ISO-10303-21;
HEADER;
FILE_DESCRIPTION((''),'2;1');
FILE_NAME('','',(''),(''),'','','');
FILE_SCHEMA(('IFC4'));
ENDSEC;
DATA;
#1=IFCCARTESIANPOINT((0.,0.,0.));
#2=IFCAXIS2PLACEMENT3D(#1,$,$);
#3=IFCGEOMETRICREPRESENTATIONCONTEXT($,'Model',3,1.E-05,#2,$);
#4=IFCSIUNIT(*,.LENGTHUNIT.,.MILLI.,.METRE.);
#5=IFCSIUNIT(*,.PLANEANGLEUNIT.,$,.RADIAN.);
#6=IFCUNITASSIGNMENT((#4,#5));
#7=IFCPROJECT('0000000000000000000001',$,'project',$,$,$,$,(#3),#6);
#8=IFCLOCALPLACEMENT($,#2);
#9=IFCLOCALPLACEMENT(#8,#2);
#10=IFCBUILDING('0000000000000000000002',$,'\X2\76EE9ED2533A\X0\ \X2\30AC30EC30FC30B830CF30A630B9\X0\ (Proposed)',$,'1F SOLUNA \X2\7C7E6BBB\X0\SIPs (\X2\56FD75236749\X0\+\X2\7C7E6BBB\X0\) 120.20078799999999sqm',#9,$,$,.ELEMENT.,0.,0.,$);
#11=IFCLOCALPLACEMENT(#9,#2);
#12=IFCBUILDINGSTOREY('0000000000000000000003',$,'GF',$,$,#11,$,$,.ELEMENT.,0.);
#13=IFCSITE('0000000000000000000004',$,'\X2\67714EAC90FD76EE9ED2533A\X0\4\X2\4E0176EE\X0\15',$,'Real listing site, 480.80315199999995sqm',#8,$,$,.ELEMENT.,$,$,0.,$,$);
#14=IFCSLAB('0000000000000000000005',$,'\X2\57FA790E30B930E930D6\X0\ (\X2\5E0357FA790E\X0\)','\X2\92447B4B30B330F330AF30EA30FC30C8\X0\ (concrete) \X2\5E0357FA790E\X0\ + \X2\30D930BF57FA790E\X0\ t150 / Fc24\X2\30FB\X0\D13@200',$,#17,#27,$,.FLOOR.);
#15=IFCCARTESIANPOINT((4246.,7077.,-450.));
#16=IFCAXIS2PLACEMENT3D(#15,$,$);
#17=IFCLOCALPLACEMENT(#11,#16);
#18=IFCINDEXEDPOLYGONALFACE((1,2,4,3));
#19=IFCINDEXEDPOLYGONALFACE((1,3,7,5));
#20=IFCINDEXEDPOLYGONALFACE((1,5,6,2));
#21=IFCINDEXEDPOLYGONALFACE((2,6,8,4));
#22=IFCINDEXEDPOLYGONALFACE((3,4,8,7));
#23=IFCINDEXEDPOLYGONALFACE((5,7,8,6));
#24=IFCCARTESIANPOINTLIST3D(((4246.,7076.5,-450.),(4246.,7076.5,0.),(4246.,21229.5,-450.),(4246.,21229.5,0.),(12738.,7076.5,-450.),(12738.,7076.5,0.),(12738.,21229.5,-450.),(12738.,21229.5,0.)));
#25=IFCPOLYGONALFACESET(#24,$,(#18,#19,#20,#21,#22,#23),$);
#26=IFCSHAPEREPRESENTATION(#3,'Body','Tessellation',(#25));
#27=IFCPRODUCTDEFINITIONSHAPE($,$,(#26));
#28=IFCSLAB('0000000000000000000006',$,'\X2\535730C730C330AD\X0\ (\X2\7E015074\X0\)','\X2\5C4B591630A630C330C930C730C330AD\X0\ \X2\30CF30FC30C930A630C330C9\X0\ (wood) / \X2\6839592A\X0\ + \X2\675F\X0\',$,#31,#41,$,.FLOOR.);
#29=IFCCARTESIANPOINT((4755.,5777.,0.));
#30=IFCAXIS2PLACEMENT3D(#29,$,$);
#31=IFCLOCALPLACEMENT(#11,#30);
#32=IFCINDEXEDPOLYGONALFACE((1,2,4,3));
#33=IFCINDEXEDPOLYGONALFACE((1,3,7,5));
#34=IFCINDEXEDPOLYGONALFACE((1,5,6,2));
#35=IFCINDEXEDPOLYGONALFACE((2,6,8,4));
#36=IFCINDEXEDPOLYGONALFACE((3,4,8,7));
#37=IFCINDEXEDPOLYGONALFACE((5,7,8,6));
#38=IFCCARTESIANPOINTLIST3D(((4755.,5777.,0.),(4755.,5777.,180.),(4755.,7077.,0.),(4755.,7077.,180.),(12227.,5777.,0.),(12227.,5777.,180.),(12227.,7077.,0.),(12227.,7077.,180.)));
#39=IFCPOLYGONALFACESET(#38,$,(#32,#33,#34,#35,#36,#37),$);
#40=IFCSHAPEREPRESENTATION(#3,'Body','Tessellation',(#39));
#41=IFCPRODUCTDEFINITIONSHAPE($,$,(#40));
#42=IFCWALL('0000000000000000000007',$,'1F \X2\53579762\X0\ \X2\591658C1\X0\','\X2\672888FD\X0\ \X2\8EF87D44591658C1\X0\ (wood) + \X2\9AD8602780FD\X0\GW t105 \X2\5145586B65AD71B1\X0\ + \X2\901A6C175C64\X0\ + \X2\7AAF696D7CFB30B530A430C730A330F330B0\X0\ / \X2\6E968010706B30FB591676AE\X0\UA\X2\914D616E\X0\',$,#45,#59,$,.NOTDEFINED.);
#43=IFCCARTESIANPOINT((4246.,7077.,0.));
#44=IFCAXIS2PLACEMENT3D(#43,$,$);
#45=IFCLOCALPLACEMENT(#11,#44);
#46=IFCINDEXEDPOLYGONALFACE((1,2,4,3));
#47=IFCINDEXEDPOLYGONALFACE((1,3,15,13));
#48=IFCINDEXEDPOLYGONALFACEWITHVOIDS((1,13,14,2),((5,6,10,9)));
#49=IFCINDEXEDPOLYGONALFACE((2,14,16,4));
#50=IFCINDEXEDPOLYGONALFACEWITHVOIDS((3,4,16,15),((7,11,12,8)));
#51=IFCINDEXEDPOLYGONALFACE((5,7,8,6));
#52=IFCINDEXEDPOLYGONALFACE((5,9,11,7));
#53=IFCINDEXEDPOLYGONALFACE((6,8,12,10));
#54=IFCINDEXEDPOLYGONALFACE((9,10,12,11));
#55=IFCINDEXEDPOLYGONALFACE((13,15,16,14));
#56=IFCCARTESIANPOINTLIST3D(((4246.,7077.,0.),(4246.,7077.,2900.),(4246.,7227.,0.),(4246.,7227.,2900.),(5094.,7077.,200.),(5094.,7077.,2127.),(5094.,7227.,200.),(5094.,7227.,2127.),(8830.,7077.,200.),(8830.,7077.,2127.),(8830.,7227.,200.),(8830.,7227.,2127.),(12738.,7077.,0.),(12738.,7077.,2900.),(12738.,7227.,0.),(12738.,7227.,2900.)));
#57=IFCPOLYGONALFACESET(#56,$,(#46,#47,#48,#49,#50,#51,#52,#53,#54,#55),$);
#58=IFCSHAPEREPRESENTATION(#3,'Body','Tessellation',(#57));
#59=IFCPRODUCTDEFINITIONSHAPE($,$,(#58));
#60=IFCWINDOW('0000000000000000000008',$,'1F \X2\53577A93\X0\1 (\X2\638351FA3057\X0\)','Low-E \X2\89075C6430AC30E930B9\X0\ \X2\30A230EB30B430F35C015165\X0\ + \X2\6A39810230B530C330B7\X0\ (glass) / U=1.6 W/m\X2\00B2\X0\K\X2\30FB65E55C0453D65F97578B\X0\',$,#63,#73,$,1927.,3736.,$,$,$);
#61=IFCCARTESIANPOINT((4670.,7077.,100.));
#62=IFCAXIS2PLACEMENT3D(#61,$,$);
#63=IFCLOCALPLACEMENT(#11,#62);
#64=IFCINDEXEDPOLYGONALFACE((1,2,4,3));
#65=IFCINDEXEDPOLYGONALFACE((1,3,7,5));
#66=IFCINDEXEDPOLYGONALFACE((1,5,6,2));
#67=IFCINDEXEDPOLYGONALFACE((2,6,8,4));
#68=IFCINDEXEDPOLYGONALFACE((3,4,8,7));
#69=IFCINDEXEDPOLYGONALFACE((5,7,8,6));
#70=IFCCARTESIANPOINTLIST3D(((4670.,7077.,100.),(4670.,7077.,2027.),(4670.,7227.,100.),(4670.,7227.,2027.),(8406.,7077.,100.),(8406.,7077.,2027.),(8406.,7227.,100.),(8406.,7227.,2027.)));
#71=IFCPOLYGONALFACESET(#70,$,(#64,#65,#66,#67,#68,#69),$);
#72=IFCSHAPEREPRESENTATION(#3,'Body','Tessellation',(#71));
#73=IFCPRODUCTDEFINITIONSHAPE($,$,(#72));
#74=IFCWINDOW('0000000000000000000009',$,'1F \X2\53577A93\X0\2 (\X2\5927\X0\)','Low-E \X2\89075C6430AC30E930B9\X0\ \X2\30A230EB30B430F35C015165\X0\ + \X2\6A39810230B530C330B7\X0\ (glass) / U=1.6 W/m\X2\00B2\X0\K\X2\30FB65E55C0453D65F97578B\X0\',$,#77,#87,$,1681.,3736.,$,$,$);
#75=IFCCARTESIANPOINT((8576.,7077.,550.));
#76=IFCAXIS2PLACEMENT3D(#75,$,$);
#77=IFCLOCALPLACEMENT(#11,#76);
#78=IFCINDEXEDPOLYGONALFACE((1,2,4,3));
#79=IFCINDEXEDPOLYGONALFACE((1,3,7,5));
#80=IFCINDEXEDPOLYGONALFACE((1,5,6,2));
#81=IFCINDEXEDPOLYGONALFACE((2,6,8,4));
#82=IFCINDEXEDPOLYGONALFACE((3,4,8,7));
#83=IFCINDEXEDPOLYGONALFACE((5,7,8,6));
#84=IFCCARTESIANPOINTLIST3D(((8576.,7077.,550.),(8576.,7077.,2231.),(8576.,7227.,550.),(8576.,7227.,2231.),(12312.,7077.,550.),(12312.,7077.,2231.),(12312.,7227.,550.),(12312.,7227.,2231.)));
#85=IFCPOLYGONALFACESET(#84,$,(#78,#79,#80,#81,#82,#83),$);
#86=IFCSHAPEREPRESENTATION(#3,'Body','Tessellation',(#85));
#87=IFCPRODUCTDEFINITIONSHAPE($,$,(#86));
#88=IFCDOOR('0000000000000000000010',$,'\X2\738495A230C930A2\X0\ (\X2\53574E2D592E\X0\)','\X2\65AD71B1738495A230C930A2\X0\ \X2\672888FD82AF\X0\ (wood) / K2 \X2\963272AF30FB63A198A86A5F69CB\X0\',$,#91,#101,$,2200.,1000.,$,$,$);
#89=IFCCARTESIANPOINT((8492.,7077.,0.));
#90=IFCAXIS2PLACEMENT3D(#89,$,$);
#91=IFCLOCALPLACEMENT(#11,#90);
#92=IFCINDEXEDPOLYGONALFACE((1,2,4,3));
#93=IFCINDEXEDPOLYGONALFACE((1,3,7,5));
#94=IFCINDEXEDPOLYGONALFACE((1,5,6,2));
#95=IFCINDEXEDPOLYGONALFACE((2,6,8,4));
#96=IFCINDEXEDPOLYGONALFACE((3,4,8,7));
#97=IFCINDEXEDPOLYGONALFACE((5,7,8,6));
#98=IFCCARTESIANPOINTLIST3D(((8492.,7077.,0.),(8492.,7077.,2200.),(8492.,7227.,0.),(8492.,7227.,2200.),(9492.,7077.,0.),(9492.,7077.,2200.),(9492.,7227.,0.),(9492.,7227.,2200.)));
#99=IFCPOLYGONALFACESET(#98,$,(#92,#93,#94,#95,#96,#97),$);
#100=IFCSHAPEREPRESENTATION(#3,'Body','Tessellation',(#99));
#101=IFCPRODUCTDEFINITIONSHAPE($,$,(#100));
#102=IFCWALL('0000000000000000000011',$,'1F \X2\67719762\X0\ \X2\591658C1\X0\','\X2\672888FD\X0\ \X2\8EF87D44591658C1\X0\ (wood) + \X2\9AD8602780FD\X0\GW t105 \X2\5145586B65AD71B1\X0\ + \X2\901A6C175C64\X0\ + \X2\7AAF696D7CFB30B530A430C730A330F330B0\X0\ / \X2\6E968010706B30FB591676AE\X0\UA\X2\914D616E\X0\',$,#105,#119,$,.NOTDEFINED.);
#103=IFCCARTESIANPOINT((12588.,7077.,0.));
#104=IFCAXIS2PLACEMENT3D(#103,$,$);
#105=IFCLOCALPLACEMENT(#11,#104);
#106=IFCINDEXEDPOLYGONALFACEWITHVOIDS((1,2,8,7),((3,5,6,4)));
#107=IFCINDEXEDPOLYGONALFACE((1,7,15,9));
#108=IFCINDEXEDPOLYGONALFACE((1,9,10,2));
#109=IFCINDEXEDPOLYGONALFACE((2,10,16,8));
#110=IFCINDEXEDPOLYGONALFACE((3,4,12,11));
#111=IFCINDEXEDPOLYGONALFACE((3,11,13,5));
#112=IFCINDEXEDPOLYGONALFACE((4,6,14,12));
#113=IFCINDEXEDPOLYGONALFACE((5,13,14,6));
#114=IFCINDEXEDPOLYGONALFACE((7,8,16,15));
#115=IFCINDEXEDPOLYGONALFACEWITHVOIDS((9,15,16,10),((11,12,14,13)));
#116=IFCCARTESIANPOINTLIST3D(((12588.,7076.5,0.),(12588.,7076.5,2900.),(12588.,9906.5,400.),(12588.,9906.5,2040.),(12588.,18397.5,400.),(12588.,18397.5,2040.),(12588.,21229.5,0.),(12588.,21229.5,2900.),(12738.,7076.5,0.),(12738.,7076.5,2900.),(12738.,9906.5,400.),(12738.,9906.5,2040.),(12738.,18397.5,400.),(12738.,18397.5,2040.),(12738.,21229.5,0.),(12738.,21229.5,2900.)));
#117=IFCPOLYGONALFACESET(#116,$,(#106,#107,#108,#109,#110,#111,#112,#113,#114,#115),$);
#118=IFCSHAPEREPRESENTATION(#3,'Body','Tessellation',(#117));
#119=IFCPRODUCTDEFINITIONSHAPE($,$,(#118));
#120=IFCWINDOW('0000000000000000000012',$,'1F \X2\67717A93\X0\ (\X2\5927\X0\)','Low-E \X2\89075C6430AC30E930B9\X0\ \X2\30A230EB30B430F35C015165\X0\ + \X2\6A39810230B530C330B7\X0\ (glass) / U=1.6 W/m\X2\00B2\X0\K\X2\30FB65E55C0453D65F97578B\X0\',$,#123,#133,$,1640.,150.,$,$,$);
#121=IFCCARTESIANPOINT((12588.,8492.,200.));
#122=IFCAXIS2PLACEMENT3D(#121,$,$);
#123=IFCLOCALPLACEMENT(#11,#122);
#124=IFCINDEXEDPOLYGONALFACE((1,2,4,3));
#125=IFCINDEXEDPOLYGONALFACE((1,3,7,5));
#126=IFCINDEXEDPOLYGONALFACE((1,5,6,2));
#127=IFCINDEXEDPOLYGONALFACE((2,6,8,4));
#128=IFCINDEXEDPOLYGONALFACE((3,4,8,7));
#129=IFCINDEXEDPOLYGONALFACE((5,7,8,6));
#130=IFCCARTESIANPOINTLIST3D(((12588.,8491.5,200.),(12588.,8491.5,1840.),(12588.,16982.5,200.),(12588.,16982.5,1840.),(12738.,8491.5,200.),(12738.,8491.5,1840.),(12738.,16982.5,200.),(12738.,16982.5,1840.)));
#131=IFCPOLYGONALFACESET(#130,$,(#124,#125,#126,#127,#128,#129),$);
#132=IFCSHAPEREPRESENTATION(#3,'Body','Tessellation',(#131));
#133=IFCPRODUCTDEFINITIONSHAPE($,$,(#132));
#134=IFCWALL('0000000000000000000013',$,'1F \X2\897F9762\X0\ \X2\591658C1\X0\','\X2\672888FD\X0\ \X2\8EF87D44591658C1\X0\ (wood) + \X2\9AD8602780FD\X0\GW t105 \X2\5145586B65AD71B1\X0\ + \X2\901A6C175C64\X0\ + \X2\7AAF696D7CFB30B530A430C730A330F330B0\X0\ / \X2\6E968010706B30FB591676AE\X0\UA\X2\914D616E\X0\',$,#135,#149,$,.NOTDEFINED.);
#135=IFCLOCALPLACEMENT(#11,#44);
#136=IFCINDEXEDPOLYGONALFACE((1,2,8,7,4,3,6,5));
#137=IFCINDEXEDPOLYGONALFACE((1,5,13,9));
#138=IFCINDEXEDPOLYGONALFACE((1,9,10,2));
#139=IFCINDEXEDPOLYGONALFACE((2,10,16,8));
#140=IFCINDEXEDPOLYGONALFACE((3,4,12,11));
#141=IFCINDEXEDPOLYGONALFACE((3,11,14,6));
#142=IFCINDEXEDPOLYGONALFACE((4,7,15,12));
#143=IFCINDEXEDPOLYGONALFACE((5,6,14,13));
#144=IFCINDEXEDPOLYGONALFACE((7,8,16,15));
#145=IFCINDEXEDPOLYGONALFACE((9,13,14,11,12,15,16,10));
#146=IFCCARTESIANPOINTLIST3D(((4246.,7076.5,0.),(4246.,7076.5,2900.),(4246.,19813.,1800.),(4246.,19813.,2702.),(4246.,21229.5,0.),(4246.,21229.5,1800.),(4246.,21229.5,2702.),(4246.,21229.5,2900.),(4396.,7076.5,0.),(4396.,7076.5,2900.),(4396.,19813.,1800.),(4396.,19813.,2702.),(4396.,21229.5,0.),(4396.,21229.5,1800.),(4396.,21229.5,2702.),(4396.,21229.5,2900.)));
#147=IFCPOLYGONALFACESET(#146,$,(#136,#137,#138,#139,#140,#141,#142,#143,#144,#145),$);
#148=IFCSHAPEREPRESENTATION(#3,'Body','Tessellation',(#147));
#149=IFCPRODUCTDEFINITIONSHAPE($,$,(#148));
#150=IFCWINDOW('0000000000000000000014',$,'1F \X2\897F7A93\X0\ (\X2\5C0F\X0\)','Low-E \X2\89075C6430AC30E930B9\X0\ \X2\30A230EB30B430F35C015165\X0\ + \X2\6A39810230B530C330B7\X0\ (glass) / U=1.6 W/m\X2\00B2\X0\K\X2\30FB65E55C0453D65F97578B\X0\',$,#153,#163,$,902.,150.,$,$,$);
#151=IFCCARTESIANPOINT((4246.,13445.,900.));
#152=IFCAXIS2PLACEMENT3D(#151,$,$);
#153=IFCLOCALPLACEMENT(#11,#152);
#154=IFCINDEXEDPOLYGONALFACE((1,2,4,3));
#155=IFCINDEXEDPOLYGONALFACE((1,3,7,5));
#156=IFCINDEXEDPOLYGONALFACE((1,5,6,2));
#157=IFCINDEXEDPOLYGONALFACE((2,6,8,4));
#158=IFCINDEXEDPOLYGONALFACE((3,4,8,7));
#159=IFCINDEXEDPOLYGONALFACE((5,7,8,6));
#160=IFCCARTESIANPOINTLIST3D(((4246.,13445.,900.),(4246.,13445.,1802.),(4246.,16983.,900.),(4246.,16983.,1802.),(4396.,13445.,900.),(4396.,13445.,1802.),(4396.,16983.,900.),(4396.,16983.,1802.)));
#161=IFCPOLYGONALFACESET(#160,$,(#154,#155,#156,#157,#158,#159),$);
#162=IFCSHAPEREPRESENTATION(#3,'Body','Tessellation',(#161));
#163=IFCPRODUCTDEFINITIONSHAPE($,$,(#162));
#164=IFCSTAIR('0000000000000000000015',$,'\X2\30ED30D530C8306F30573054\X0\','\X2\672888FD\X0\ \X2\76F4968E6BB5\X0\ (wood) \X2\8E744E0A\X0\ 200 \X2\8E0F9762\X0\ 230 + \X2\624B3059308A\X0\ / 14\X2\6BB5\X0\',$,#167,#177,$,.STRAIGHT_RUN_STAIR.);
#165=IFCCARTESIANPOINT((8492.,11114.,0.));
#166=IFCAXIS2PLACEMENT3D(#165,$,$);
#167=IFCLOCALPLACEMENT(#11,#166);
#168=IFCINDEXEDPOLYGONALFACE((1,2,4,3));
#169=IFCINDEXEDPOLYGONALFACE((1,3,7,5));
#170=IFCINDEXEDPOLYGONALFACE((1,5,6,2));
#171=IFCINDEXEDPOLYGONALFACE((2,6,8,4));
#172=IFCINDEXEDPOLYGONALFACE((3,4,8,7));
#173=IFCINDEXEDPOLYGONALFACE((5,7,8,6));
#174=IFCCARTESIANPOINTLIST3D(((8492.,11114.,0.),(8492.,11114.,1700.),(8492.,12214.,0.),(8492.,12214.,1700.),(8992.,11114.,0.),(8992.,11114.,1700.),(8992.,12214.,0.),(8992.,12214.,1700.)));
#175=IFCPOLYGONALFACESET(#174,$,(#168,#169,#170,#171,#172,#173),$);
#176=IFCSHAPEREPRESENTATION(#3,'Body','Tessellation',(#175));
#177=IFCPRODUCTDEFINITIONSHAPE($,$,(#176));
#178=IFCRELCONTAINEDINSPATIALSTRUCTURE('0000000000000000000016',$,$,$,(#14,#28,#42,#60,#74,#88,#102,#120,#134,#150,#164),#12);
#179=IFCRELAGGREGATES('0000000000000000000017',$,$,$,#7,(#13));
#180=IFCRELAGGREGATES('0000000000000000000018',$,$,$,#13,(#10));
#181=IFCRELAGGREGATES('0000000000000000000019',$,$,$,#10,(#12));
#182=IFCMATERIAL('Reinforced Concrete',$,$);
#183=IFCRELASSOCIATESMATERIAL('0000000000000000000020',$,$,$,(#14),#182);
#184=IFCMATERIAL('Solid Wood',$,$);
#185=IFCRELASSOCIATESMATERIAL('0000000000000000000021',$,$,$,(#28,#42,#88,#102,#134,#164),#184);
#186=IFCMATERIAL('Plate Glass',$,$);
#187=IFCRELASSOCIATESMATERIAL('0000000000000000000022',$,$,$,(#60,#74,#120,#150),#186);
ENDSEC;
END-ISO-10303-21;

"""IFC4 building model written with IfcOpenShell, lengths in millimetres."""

from ifc_helpers import new_model, si_unit, frame, frame_2d, origin, place, context, project, spatial, rectangle, extrude, material, element, fill, save


model = new_model("IFC4")

# Units and contexts
model_context = context("Model", 3, precision=1e-05, world=origin())
ifc_project = project(units=[si_unit("LENGTHUNIT", "METRE", prefix="MILLI"), si_unit("PLANEANGLEUNIT", "RADIAN")], contexts=[model_context])

# Site, building, storey
site_placement = place(None, origin())
site = spatial("IfcSite", under=ifc_project, at=site_placement, Name="東京都目黒区4丁目15", ObjectType="Real listing site, 480.80315199999995sqm", CompositionType="ELEMENT", RefElevation=0.0)
building_placement = place(site_placement, origin())
building = spatial("IfcBuilding", under=site, at=building_placement, Name="目黒区 ガレージハウス (Proposed)", ObjectType="1F SOLUNA 籾殻SIPs (国産杉+籾殻) 120.20078799999999sqm", CompositionType="ELEMENT", ElevationOfRefHeight=0.0, ElevationOfTerrain=0.0)
storey_placement = place(building_placement, origin())
storey = spatial("IfcBuildingStorey", under=building, at=storey_placement, Name="GF", CompositionType="ELEMENT", Elevation=0.0)

# Slabs
ifc_material_1 = material(Name="Reinforced Concrete")
slab_1_placement = place(storey_placement, frame((4246.0, 7077.0, -450.0)))
element("IfcSlab", 1, at=slab_1_placement, inside=storey, material=ifc_material_1, Name="基礎スラブ (布基礎)", Description="鉄筋コンクリート (concrete) 布基礎 + ベタ基礎 t150 / Fc24・D13@200", PredefinedType="FLOOR", context=model_context, shape_type="SweptSolid", body=[
    extrude(rectangle(XDim=8492.0, YDim=14153.0, at=frame_2d((4246.0, 7076.0))), frame((4246.0, 7077.0, -450.0)), (0.0, 0.0, 1.0), 450.0),
])
ifc_material_2 = material(Name="Solid Wood")
slab_2_placement = place(storey_placement, frame((4755.0, 5777.0, 0.0)))
element("IfcSlab", 2, at=slab_2_placement, inside=storey, material=ifc_material_2, Name="南デッキ (縁側)", Description="屋外ウッドデッキ ハードウッド (wood) / 根太 + 束", PredefinedType="FLOOR", context=model_context, shape_type="SweptSolid", body=[
    extrude(rectangle(XDim=7472.0, YDim=1300.0, at=frame_2d((3736.0, 650.0))), frame((4755.0, 5777.0, 0.0)), (0.0, 0.0, 1.0), 180.0),
])

# Wall, openings, windows, door
wall_1_placement = place(storey_placement, frame((4246.0, 7077.0, 0.0)))
wall_1 = element("IfcWall", 3, at=wall_1_placement, inside=storey, material=ifc_material_2, Name="1F 南面 外壁", Description="木製 軸組外壁 (wood) + 高性能GW t105 充填断熱 + 通気層 + 窯業系サイディング / 準耐火・外皮UA配慮", PredefinedType="NOTDEFINED", context=model_context, shape_type="SweptSolid", body=[
    extrude(rectangle(XDim=8492.0, YDim=150.0, at=frame_2d((4246.0, 75.0))), frame((4246.0, 7077.0, 0.0)), (0.0, 0.0, 1.0), 2900.0),
])
opening_1_placement = place(storey_placement, frame((4670.0, 7077.0, 100.0)))
opening_1 = element("IfcOpeningElement", 4, at=opening_1_placement, cuts=wall_1, PredefinedType="NOTDEFINED", context=model_context, shape_type="SweptSolid", body=[
    extrude(rectangle(XDim=3736.0, YDim=150.0, at=frame_2d((1868.0, 75.0))), frame((4670.0, 7077.0, 100.0)), (0.0, 0.0, 1.0), 1927.0),
])
opening_2_placement = place(storey_placement, frame((8576.0, 7077.0, 550.0)))
opening_2 = element("IfcOpeningElement", 5, at=opening_2_placement, cuts=wall_1, PredefinedType="NOTDEFINED", context=model_context, shape_type="SweptSolid", body=[
    extrude(rectangle(XDim=3736.0, YDim=150.0, at=frame_2d((1868.0, 75.0))), frame((8576.0, 7077.0, 550.0)), (0.0, 0.0, 1.0), 1681.0),
])
opening_3_placement = place(storey_placement, frame((8492.0, 7077.0, 0.0)))
opening_3 = element("IfcOpeningElement", 6, at=opening_3_placement, cuts=wall_1, PredefinedType="NOTDEFINED", context=model_context, shape_type="SweptSolid", body=[
    extrude(rectangle(XDim=1000.0, YDim=150.0, at=frame_2d((500.0, 75.0))), frame((8492.0, 7077.0, 0.0)), (0.0, 0.0, 1.0), 2200.0),
])
ifc_material_3 = material(Name="Plate Glass")
window_1_placement = place(storey_placement, frame((4670.0, 7077.0, 100.0)))
window_1 = element("IfcWindow", 7, at=window_1_placement, inside=storey, material=ifc_material_3, Name="1F 南窓1 (掃出し)", Description="Low-E 複層ガラス アルゴン封入 + 樹脂サッシ (glass) / U=1.6 W/m²K・日射取得型", OverallHeight=1927.0, OverallWidth=3736.0, context=model_context, shape_type="SweptSolid", body=[
    extrude(rectangle(XDim=3736.0, YDim=150.0, at=frame_2d((1868.0, 75.0))), frame((4670.0, 7077.0, 100.0)), (0.0, 0.0, 1.0), 1927.0),
])
fill(opening_1, window_1)
window_2_placement = place(storey_placement, frame((8576.0, 7077.0, 550.0)))
window_2 = element("IfcWindow", 8, at=window_2_placement, inside=storey, material=ifc_material_3, Name="1F 南窓2 (大)", Description="Low-E 複層ガラス アルゴン封入 + 樹脂サッシ (glass) / U=1.6 W/m²K・日射取得型", OverallHeight=1681.0, OverallWidth=3736.0, context=model_context, shape_type="SweptSolid", body=[
    extrude(rectangle(XDim=3736.0, YDim=150.0, at=frame_2d((1868.0, 75.0))), frame((8576.0, 7077.0, 550.0)), (0.0, 0.0, 1.0), 1681.0),
])
fill(opening_2, window_2)
door_placement = place(storey_placement, frame((8492.0, 7077.0, 0.0)))
door = element("IfcDoor", 9, at=door_placement, inside=storey, material=ifc_material_2, Name="玄関ドア (南中央)", Description="断熱玄関ドア 木製芯 (wood) / K2 防犯・採風機構", OverallHeight=2200.0, OverallWidth=1000.0, context=model_context, shape_type="SweptSolid", body=[
    extrude(rectangle(XDim=1000.0, YDim=150.0, at=frame_2d((500.0, 75.0))), frame((8492.0, 7077.0, 0.0)), (0.0, 0.0, 1.0), 2200.0),
])
fill(opening_3, door)

# Walls, openings, windows
wall_2_placement = place(storey_placement, frame((12588.0, 7077.0, 0.0)))
wall_2 = element("IfcWall", 10, at=wall_2_placement, inside=storey, material=ifc_material_2, Name="1F 東面 外壁", Description="木製 軸組外壁 (wood) + 高性能GW t105 充填断熱 + 通気層 + 窯業系サイディング / 準耐火・外皮UA配慮", PredefinedType="NOTDEFINED", context=model_context, shape_type="SweptSolid", body=[
    extrude(rectangle(XDim=150.0, YDim=14153.0, at=frame_2d((75.0, 7076.0))), frame((12588.0, 7077.0, 0.0)), (0.0, 0.0, 1.0), 2900.0),
])
opening_4_placement = place(storey_placement, frame((12588.0, 8492.0, 200.0)))
opening_4 = element("IfcOpeningElement", 11, at=opening_4_placement, cuts=wall_2, PredefinedType="NOTDEFINED", context=model_context, shape_type="SweptSolid", body=[
    extrude(rectangle(XDim=150.0, YDim=8491.0, at=frame_2d((75.0, 4245.0))), frame((12588.0, 8492.0, 200.0)), (0.0, 0.0, 1.0), 1640.0),
])
window_3_placement = place(storey_placement, frame((12588.0, 8492.0, 200.0)))
window_3 = element("IfcWindow", 12, at=window_3_placement, inside=storey, material=ifc_material_3, Name="1F 東窓 (大)", Description="Low-E 複層ガラス アルゴン封入 + 樹脂サッシ (glass) / U=1.6 W/m²K・日射取得型", OverallHeight=1640.0, OverallWidth=150.0, context=model_context, shape_type="SweptSolid", body=[
    extrude(rectangle(XDim=150.0, YDim=8491.0, at=frame_2d((75.0, 4245.0))), frame((12588.0, 8492.0, 200.0)), (0.0, 0.0, 1.0), 1640.0),
])
fill(opening_4, window_3)
wall_3_placement = place(storey_placement, frame((4246.0, 7077.0, 0.0)))
wall_3 = element("IfcWall", 13, at=wall_3_placement, inside=storey, material=ifc_material_2, Name="1F 西面 外壁", Description="木製 軸組外壁 (wood) + 高性能GW t105 充填断熱 + 通気層 + 窯業系サイディング / 準耐火・外皮UA配慮", PredefinedType="NOTDEFINED", context=model_context, shape_type="SweptSolid", body=[
    extrude(rectangle(XDim=150.0, YDim=14153.0, at=frame_2d((75.0, 7076.0))), frame((4246.0, 7077.0, 0.0)), (0.0, 0.0, 1.0), 2900.0),
])
opening_5_placement = place(storey_placement, frame((4246.0, 13445.0, 900.0)))
opening_5 = element("IfcOpeningElement", 14, at=opening_5_placement, cuts=wall_3, PredefinedType="NOTDEFINED", context=model_context, shape_type="SweptSolid", body=[
    extrude(rectangle(XDim=150.0, YDim=3538.0, at=frame_2d((75.0, 1769.0))), frame((4246.0, 13445.0, 900.0)), (0.0, 0.0, 1.0), 902.0),
])
window_4_placement = place(storey_placement, frame((4246.0, 13445.0, 900.0)))
window_4 = element("IfcWindow", 15, at=window_4_placement, inside=storey, material=ifc_material_3, Name="1F 西窓 (小)", Description="Low-E 複層ガラス アルゴン封入 + 樹脂サッシ (glass) / U=1.6 W/m²K・日射取得型", OverallHeight=902.0, OverallWidth=150.0, context=model_context, shape_type="SweptSolid", body=[
    extrude(rectangle(XDim=150.0, YDim=3538.0, at=frame_2d((75.0, 1769.0))), frame((4246.0, 13445.0, 900.0)), (0.0, 0.0, 1.0), 902.0),
])
fill(opening_5, window_4)

# Stair
stair_placement = place(storey_placement, frame((8492.0, 11114.0, 0.0)))
element("IfcStair", 16, at=stair_placement, inside=storey, material=ifc_material_2, Name="ロフトはしご", Description="木製 直階段 (wood) 蹴上 200 踏面 230 + 手すり / 14段", PredefinedType="STRAIGHT_RUN_STAIR", context=model_context, shape_type="SweptSolid", body=[
    extrude(rectangle(XDim=500.0, YDim=1100.0, at=frame_2d((250.0, 550.0))), frame((8492.0, 11114.0, 0.0)), (0.0, 0.0, 1.0), 1700.0),
])

save(model, "model.ifc")
